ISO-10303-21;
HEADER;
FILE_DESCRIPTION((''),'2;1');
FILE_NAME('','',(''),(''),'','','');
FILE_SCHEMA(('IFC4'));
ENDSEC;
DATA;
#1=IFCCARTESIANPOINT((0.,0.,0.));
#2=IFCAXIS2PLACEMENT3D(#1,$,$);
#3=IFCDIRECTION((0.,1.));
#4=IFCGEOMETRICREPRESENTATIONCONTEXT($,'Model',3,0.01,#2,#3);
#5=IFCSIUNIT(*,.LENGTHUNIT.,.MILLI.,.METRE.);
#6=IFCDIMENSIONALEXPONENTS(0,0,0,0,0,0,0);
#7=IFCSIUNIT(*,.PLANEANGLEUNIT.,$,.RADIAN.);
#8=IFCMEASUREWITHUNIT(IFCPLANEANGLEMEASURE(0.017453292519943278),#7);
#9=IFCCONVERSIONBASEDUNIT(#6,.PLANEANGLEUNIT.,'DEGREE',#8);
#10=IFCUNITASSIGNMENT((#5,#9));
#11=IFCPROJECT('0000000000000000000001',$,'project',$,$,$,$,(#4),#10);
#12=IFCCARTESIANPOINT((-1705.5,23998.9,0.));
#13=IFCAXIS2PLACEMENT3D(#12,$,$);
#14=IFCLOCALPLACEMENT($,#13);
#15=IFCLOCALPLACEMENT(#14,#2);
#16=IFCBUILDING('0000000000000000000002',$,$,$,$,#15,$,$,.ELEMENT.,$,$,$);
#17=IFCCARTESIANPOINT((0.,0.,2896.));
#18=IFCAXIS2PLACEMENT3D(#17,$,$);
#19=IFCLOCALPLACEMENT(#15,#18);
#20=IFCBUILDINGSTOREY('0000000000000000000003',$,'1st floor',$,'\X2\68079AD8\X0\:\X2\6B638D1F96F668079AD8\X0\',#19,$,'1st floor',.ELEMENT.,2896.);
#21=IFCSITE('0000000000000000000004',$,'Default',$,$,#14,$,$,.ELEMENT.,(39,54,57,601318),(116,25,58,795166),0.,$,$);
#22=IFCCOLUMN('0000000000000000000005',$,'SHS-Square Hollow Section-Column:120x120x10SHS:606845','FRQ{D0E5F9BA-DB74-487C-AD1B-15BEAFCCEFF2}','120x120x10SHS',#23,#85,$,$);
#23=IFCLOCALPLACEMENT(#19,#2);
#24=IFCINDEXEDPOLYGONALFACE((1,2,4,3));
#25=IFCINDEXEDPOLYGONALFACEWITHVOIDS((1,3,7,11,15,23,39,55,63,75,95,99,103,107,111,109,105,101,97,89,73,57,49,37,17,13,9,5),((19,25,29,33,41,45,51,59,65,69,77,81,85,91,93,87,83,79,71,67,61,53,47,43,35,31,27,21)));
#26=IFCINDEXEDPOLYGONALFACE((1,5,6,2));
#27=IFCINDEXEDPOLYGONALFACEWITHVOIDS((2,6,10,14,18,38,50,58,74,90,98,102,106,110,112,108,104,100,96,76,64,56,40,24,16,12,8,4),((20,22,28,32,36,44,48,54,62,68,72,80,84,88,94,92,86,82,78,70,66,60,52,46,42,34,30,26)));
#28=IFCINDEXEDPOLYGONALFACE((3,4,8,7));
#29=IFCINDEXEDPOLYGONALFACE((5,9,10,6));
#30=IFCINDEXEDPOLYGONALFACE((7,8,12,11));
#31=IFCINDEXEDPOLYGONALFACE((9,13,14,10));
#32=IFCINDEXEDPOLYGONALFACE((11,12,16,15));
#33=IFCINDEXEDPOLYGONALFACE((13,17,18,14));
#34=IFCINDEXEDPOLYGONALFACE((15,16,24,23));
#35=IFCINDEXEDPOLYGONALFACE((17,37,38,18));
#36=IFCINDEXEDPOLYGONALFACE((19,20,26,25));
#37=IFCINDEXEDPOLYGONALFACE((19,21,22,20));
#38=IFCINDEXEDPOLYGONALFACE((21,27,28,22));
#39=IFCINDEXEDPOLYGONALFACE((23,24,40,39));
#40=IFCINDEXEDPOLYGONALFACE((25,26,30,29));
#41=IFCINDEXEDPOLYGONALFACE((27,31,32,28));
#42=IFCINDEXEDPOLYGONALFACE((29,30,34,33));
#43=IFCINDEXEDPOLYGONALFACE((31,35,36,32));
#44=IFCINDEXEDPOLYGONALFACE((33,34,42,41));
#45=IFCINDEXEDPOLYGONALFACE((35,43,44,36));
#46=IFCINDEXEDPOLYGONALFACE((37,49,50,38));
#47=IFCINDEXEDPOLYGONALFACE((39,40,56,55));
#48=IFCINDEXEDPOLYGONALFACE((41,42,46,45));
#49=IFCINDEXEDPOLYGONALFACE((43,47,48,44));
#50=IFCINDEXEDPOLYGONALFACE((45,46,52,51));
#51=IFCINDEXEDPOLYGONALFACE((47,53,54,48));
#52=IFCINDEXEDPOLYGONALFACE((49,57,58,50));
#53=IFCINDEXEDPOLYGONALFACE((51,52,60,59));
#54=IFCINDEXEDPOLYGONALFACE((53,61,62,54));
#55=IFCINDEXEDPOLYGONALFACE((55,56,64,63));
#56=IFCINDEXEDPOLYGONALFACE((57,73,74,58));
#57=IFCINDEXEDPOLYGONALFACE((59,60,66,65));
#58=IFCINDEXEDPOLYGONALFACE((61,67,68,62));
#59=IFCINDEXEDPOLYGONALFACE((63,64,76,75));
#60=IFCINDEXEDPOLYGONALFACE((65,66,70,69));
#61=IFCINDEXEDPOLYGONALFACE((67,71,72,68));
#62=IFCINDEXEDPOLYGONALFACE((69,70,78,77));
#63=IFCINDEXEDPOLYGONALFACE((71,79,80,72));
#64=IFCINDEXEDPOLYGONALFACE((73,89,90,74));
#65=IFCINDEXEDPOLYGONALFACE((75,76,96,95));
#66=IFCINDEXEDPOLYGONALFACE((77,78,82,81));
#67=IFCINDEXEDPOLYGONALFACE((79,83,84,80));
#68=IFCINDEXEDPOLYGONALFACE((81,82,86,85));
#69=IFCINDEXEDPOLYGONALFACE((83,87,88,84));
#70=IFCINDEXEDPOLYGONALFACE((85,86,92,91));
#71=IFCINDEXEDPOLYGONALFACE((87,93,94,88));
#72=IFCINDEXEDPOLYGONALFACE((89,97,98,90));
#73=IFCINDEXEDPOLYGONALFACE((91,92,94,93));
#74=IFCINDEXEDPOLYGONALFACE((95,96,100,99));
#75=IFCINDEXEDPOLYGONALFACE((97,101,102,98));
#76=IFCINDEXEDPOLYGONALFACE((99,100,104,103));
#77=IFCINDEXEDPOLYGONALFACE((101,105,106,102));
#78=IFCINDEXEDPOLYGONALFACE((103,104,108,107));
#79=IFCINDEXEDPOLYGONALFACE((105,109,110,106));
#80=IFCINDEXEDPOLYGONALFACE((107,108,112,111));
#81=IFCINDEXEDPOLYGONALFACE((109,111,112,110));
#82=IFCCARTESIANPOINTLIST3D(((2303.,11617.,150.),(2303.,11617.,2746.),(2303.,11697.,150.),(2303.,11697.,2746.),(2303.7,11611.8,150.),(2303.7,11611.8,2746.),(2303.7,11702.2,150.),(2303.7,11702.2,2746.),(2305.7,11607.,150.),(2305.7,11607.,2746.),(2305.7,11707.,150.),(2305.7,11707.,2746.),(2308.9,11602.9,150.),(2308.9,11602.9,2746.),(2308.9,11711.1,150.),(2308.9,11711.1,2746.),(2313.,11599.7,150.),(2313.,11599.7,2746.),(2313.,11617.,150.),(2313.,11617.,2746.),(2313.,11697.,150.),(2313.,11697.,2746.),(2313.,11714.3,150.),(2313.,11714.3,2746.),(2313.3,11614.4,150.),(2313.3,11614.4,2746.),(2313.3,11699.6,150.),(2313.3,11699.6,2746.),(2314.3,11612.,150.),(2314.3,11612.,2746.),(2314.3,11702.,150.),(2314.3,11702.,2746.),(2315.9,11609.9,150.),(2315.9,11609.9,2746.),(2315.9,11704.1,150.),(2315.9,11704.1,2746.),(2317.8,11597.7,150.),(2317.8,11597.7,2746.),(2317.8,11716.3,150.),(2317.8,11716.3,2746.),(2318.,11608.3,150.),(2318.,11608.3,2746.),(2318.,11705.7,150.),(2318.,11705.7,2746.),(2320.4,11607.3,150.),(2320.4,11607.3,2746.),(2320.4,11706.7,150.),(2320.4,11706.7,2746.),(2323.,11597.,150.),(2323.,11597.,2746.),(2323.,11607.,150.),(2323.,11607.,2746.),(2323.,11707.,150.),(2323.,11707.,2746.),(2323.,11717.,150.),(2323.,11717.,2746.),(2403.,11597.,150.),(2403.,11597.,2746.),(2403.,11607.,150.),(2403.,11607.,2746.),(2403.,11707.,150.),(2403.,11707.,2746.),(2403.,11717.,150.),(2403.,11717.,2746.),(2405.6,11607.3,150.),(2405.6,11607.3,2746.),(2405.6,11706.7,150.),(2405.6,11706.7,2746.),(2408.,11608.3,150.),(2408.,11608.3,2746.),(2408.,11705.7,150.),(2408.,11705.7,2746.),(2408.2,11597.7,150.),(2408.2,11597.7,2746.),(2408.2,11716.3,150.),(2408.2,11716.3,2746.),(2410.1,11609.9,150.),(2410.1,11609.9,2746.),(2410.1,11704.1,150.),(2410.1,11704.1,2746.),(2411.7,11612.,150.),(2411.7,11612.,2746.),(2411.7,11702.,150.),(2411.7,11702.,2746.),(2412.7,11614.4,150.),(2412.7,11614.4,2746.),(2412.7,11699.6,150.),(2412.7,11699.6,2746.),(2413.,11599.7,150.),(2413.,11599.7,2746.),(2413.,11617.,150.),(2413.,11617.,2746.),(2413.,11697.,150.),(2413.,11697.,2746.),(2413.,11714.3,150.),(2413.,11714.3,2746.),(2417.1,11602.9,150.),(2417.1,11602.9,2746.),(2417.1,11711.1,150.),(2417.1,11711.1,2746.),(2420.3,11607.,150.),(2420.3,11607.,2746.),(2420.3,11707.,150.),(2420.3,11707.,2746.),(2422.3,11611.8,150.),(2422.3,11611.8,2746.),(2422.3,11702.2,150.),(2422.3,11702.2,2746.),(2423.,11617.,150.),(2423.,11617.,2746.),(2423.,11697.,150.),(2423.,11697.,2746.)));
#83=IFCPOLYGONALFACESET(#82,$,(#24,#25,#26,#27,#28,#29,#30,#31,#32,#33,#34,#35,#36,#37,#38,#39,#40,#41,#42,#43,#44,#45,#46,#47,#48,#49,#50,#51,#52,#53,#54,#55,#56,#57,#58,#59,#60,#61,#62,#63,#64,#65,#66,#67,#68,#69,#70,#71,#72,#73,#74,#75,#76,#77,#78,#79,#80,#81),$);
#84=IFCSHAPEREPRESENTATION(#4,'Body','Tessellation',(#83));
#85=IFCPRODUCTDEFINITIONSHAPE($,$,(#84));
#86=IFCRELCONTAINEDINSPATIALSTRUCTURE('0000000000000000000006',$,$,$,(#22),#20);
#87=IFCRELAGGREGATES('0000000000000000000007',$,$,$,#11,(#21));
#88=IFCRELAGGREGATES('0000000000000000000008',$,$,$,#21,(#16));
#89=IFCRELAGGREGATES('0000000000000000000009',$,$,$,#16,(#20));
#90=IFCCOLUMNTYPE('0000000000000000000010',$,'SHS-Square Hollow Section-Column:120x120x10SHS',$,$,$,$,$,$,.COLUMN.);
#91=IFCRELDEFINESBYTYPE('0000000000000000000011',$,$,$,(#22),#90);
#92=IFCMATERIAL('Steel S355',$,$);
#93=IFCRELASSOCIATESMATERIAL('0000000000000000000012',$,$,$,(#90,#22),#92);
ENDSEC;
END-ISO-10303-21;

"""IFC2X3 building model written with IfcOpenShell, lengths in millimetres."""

from ifc_helpers import new_model, entity, si_unit, converted_unit, direction, frame, origin, origin_2d, place, context, project, spatial, hollow_rectangle, extrude, clip, halfspace, material, type_object, element, save


model = new_model("IFC2X3")

# Units and contexts
model_context = context("Model", 3, precision=0.01, world=origin(), true_north=direction((0.0, 1.0)))
ifc_project = project(units=[si_unit("LENGTHUNIT", "METRE", prefix="MILLI"), converted_unit("PLANEANGLEUNIT", "DEGREE", entity("IfcPlaneAngleMeasure", 0.017453292519943278), si_unit("PLANEANGLEUNIT", "RADIAN"), dimensions=[0, 0, 0, 0, 0, 0, 0])], contexts=[model_context])

# Site, building, storey
site_placement = place(None, frame((-1705.5, 23998.9, 0.0)))
site = spatial("IfcSite", under=ifc_project, at=site_placement, Name="Default", CompositionType="ELEMENT", RefLatitude=(39, 54, 57, 601318), RefLongitude=(116, 25, 58, 795166), RefElevation=0.0)
building_placement = place(site_placement, origin())
building = spatial("IfcBuilding", under=site, at=building_placement, CompositionType="ELEMENT")
storey_placement = place(building_placement, frame((0.0, 0.0, 2896.0)))
storey = spatial("IfcBuildingStorey", under=building, at=storey_placement, Name="1st floor", ObjectType="标高:正负零标高", LongName="1st floor", CompositionType="ELEMENT", Elevation=2896.0)

# Column
ifc_material_1 = material(Name="Steel S355")
column_type_1 = type_object("IfcColumnType", Name="SHS-Square Hollow Section-Column:120x120x10SHS", PredefinedType="COLUMN", material=ifc_material_1)
column_1_placement = place(storey_placement, frame((2363.0, 11657.0, 2830.9), z_axis=(0.0, 0.0, 1.0), x_axis=(0.0, -1.0, 0.0)))
element("IfcColumn", 1, at=column_1_placement, inside=storey, type_object=column_type_1, material=ifc_material_1, Name="SHS-Square Hollow Section-Column:120x120x10SHS:606845", Description="FRQ{D0E5F9BA-DB74-487C-AD1B-15BEAFCCEFF2}", ObjectType="120x120x10SHS", context=model_context, shape_type="Clipping", body=[
    clip(clip(extrude(hollow_rectangle(XDim=120.0, YDim=120.0, WallThickness=10.0, InnerFilletRadius=10.0, OuterFilletRadius=20.0, at=origin_2d()), origin(), (0.0, 0.0, -1.0), 2765.7), halfspace(frame((11657.0, -2363.0, -84.9), z_axis=(0.0, 0.0, -1.0), x_axis=(0.0, -1.0, 0.0)), True)), halfspace(frame((11657.0, -2363.0, -2680.9), z_axis=(0.0, 0.0, 1.0), x_axis=(0.0, 1.0, 0.0)), True)),
])

save(model, "model.ifc")
